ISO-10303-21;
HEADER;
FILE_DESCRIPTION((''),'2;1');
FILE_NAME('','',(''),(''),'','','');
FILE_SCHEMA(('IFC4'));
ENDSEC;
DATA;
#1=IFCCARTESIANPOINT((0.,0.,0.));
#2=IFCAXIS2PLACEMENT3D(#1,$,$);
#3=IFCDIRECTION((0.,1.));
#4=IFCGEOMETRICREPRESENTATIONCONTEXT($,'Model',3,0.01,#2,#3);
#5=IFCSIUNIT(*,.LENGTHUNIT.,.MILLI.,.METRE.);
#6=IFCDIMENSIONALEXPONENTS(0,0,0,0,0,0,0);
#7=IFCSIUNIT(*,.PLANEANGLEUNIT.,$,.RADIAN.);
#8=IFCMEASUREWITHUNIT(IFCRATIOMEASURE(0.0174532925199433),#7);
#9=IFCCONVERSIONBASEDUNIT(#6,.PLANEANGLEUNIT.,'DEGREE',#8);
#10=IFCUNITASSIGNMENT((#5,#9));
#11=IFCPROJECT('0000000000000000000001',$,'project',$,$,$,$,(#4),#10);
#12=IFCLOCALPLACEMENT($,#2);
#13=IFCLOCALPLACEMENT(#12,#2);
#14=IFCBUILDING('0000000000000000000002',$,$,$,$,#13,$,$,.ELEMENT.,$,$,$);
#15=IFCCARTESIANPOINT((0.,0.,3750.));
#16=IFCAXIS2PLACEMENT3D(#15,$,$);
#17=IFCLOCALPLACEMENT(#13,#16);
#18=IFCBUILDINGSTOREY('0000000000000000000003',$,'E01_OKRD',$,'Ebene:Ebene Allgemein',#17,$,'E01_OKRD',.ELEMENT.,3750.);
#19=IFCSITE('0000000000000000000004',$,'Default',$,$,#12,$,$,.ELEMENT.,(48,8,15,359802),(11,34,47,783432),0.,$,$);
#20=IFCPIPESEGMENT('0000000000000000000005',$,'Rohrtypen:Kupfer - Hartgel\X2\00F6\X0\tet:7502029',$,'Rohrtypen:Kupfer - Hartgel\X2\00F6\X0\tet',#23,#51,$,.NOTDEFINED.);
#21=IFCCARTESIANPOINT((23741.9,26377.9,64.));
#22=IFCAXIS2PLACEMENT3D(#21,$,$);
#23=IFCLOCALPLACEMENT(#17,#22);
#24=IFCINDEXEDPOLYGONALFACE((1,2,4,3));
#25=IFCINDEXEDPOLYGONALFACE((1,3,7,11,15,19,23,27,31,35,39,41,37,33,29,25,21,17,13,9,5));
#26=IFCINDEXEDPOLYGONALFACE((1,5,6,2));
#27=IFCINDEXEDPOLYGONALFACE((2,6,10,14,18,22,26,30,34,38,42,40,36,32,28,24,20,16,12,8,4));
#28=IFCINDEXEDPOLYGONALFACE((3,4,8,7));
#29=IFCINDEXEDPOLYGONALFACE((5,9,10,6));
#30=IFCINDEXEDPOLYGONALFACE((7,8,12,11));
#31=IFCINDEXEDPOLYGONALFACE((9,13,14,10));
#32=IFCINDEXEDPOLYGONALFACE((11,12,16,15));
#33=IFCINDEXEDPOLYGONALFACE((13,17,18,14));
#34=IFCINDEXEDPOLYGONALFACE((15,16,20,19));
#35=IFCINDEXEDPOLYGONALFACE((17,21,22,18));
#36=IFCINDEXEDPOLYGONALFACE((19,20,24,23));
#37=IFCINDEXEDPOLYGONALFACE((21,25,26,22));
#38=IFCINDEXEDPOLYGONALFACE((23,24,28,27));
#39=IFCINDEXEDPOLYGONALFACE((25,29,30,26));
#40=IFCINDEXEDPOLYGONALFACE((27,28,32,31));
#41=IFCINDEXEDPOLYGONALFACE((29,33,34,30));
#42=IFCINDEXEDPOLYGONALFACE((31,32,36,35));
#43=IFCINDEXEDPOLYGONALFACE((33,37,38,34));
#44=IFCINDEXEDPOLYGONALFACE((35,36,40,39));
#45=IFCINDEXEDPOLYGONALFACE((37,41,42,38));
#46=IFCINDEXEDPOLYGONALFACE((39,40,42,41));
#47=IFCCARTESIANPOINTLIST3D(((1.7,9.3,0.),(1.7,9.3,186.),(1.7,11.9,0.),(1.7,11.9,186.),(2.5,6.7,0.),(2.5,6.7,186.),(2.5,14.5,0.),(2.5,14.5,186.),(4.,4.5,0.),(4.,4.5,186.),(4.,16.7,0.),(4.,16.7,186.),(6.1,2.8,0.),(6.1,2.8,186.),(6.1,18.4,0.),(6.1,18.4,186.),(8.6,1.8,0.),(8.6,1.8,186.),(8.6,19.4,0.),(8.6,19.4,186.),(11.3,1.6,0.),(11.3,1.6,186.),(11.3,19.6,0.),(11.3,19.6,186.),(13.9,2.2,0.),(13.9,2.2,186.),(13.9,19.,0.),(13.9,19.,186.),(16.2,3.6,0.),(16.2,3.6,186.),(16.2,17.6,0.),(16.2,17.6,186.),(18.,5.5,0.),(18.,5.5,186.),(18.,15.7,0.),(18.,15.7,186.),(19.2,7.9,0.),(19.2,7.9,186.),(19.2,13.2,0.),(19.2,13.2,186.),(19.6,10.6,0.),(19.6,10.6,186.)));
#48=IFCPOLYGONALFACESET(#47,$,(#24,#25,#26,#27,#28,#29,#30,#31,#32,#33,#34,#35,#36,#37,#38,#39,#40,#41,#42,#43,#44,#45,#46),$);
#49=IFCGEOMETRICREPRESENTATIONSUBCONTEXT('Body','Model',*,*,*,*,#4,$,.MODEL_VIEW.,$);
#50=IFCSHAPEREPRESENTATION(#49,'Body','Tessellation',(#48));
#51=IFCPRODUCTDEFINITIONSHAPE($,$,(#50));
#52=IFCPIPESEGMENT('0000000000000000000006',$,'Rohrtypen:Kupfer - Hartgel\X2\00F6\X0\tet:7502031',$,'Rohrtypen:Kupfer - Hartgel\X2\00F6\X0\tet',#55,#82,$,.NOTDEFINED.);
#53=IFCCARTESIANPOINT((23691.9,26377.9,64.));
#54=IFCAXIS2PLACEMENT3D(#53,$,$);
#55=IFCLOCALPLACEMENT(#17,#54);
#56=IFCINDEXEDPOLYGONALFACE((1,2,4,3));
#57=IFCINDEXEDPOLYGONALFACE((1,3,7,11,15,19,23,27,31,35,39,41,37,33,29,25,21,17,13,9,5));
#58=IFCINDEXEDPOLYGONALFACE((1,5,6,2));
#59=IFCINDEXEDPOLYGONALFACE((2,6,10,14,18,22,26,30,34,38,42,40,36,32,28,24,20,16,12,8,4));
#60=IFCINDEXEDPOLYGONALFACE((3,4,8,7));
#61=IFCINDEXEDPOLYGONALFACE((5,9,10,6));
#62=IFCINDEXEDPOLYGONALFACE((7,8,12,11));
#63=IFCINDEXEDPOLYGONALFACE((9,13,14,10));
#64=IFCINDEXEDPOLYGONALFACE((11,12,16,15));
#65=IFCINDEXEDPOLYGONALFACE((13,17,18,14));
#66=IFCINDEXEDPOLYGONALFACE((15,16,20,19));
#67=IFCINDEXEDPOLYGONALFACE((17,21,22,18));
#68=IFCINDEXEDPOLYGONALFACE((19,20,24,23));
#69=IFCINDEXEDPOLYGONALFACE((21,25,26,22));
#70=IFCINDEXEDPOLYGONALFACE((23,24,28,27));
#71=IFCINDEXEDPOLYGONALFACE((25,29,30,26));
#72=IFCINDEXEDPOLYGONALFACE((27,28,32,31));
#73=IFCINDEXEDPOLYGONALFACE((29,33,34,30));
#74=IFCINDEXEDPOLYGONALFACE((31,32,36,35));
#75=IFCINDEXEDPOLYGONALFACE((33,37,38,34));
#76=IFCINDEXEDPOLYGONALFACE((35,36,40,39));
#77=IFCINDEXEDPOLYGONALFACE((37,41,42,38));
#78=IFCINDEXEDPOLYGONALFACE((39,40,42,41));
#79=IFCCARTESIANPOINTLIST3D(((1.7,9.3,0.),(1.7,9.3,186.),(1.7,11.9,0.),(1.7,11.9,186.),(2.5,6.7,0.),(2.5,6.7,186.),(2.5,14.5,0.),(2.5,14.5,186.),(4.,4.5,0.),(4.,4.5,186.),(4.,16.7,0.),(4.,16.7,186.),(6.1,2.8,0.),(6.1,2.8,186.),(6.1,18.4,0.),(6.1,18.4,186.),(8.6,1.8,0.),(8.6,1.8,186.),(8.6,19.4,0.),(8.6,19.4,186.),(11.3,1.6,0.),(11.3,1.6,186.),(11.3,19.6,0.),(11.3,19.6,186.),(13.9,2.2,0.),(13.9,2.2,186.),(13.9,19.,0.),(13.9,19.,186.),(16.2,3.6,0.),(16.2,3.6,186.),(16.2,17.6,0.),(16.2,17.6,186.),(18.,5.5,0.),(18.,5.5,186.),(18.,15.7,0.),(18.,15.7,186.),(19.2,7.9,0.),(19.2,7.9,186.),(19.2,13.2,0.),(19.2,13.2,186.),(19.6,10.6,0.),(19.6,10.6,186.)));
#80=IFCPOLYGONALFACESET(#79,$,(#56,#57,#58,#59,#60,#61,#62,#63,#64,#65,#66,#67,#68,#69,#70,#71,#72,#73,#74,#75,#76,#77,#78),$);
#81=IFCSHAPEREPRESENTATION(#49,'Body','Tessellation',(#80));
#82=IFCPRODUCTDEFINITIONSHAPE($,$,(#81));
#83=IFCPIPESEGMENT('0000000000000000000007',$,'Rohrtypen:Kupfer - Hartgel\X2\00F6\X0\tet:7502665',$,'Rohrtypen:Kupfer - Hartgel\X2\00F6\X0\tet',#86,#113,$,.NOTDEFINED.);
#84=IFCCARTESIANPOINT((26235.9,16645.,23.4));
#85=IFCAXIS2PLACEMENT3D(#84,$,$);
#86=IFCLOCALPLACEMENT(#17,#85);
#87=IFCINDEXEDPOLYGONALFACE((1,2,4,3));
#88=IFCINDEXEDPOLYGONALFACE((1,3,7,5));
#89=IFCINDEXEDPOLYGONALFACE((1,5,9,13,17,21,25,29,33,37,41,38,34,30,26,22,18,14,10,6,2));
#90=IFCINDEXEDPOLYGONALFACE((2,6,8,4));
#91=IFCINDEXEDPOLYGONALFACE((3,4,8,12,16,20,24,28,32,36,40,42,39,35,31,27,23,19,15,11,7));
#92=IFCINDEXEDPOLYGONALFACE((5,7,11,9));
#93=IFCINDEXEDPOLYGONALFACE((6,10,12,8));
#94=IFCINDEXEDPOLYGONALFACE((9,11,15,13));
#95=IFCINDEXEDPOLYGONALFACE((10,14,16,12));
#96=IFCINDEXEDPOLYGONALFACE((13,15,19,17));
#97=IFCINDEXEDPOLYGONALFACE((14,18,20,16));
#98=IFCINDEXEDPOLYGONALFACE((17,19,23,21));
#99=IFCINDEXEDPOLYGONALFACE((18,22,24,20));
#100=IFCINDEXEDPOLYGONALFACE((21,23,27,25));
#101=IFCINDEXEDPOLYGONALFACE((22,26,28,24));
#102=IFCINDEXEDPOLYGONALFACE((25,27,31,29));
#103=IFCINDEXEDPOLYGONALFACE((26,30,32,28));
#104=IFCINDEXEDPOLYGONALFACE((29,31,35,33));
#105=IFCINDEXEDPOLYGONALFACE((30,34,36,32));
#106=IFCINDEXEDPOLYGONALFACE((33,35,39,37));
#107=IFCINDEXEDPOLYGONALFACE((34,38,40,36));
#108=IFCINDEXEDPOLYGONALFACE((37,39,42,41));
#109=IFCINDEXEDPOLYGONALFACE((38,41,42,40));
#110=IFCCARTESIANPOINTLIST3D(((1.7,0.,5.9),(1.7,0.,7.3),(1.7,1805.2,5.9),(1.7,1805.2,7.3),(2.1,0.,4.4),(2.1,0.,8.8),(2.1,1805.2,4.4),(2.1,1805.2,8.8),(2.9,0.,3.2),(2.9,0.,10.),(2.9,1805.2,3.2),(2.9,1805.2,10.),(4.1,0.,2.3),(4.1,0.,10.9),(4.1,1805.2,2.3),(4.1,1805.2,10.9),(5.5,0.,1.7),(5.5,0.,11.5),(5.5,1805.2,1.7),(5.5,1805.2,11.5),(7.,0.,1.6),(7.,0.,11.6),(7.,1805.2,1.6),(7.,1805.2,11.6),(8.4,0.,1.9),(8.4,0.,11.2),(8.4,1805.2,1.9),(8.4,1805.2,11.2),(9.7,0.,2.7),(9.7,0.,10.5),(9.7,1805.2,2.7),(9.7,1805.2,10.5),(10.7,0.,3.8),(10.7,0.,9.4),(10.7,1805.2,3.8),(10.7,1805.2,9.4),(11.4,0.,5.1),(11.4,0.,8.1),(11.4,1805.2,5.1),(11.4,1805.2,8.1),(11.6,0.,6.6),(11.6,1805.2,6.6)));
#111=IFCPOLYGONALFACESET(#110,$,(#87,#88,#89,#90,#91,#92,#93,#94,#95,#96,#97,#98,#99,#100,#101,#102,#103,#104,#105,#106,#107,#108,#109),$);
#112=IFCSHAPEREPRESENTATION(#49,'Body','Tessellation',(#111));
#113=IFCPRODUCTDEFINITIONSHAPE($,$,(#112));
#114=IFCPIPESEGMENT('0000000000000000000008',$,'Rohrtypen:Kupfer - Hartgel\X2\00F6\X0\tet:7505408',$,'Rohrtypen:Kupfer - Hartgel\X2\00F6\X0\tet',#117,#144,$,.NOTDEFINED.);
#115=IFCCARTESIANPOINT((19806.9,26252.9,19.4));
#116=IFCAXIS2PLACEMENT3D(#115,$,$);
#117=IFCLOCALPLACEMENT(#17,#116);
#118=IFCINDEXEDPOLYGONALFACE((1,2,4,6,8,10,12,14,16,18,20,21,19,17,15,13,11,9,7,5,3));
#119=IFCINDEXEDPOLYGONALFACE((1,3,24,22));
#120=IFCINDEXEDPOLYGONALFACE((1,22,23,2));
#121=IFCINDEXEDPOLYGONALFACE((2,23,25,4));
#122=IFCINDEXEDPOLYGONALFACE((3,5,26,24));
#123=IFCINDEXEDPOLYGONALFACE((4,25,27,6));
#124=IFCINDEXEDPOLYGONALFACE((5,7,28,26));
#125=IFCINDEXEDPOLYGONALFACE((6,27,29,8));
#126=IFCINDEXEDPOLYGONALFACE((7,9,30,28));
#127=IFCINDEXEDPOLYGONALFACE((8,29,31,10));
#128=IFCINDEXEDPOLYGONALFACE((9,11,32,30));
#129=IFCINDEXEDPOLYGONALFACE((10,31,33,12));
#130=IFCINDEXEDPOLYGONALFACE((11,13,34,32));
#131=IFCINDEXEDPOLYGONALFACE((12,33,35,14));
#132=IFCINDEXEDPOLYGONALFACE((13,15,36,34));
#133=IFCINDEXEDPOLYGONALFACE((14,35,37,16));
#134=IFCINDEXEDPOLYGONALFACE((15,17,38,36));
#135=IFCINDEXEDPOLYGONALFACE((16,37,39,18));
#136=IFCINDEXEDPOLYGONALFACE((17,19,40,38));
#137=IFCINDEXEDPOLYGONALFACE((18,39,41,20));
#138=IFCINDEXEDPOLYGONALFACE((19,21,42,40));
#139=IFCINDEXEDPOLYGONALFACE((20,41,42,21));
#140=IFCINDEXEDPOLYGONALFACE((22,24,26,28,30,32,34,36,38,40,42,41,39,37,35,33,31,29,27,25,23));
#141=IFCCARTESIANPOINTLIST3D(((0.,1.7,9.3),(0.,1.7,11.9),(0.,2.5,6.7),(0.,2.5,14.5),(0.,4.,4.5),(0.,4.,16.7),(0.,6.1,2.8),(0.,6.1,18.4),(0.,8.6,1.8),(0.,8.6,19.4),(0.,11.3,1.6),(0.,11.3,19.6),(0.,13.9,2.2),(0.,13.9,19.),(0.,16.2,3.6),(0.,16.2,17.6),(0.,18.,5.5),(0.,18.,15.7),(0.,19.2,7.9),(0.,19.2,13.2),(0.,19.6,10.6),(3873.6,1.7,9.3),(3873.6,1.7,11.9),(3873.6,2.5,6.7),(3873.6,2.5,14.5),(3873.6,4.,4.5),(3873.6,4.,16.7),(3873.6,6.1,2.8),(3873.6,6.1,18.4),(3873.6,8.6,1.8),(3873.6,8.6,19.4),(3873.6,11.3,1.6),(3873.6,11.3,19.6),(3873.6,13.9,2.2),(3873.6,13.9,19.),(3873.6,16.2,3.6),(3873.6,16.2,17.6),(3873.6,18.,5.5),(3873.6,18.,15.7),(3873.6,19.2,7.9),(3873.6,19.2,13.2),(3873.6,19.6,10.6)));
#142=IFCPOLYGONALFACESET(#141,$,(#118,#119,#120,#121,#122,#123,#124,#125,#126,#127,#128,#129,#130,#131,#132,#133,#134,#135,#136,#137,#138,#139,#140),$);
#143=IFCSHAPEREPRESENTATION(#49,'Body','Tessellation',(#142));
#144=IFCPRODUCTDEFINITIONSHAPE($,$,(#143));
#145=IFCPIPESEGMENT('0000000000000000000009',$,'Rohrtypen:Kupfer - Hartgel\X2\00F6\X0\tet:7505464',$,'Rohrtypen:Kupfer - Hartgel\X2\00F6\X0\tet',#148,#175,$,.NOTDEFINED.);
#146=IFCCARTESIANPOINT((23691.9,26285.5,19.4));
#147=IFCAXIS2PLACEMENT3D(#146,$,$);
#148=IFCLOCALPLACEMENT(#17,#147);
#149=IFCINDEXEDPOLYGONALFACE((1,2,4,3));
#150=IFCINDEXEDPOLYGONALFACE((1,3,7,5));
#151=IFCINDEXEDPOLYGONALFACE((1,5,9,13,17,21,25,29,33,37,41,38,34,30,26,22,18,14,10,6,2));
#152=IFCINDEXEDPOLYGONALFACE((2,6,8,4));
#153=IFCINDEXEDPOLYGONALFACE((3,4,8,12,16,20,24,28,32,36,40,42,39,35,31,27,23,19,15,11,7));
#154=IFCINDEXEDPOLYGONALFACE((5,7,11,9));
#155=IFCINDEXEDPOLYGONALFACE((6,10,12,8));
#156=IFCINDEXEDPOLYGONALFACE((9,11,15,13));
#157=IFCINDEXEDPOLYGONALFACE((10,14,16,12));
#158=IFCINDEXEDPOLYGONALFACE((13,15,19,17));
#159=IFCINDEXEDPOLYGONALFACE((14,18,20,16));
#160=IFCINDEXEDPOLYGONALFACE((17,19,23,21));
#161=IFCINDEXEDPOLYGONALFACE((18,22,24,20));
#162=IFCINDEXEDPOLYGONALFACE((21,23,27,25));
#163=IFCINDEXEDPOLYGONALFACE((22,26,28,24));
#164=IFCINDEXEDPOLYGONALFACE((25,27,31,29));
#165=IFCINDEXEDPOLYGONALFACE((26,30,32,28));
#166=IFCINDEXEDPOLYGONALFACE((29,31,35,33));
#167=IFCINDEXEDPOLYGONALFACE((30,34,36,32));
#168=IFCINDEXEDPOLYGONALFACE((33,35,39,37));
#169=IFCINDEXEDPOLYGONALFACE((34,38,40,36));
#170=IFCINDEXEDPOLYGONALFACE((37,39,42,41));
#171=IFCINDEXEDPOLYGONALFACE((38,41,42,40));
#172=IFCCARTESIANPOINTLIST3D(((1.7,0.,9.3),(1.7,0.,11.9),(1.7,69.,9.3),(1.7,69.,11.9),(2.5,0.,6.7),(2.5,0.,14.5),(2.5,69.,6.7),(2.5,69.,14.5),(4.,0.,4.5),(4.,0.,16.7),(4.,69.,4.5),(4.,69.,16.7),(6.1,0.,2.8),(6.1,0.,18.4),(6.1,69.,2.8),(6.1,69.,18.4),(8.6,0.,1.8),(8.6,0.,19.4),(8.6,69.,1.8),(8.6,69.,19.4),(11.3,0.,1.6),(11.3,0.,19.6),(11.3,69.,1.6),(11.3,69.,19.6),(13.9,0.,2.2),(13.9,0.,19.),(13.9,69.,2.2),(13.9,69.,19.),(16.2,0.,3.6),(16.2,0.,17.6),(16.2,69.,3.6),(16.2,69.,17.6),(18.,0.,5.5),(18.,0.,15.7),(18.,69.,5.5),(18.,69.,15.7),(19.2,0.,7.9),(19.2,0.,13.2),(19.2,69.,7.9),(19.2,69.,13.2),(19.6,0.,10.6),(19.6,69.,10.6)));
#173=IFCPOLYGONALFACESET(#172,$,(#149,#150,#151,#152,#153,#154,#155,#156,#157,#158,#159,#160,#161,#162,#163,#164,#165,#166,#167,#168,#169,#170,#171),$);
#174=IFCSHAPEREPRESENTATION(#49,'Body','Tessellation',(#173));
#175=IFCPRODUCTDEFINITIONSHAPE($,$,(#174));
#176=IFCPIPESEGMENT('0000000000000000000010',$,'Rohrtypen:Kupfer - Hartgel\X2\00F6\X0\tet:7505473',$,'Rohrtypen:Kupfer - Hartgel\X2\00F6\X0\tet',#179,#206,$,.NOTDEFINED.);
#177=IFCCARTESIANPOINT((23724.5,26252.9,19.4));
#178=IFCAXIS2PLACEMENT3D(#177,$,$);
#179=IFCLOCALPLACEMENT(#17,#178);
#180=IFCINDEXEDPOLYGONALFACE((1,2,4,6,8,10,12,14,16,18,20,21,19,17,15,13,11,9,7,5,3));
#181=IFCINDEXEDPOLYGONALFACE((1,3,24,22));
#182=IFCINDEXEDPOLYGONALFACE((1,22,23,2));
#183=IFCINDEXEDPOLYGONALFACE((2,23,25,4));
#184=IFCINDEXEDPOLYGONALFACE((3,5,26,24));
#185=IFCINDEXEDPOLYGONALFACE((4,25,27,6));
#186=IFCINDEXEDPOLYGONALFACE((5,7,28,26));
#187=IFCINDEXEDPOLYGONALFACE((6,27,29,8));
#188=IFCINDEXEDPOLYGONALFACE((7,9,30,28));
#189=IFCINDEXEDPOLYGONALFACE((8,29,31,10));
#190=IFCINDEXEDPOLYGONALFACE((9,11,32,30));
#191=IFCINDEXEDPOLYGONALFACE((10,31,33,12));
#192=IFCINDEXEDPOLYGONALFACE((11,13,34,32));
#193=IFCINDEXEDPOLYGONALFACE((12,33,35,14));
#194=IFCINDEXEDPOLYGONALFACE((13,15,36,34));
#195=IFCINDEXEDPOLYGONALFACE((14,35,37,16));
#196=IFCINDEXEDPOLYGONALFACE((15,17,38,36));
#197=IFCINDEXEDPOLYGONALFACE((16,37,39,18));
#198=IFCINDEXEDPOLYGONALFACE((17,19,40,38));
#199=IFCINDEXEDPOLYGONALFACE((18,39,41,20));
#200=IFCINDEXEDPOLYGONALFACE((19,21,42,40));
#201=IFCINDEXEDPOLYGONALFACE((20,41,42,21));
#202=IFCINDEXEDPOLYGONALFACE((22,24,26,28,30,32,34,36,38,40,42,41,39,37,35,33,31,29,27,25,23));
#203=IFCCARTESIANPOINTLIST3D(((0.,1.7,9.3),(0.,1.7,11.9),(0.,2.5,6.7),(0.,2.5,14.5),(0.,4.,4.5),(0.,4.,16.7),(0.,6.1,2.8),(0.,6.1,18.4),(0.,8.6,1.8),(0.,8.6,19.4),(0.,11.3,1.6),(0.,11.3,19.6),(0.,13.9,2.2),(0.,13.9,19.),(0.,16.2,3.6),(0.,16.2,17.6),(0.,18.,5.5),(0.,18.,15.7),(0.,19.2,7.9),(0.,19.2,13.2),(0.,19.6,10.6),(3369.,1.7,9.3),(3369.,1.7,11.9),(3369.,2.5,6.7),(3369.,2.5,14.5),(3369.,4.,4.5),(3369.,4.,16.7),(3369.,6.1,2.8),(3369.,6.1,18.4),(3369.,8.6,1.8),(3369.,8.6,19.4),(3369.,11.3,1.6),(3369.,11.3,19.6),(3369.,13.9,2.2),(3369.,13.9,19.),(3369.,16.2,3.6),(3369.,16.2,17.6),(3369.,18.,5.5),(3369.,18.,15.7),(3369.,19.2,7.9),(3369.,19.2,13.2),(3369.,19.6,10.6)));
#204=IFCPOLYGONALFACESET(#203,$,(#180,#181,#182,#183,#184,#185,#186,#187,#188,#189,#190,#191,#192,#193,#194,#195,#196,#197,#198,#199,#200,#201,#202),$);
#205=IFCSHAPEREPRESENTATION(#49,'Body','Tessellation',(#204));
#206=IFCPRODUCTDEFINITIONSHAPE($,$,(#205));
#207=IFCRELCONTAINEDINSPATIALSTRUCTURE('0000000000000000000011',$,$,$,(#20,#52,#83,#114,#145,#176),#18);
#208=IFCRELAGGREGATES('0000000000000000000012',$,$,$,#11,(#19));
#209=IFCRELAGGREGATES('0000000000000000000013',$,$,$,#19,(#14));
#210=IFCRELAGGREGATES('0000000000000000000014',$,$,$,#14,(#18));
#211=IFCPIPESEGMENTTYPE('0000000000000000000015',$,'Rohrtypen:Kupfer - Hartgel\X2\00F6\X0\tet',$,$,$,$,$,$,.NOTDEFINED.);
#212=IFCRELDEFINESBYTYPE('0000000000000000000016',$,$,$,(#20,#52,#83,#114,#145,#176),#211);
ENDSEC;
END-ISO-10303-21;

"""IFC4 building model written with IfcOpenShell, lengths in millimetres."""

from ifc_helpers import new_model, entity, si_unit, converted_unit, direction, frame, frame_2d, origin, origin_2d_with_axis, place, context, subcontext, project, spatial, circle, extrude, type_object, element, save


model = new_model("IFC4")

# Units and contexts
model_context = context("Model", 3, precision=0.01, world=origin(), true_north=direction((0.0, 1.0)))
body_context = subcontext(model_context, "Body", "Model", "MODEL_VIEW")
ifc_project = project(units=[si_unit("LENGTHUNIT", "METRE", prefix="MILLI"), converted_unit("PLANEANGLEUNIT", "DEGREE", entity("IfcRatioMeasure", 0.0174532925199433), si_unit("PLANEANGLEUNIT", "RADIAN"), dimensions=[0, 0, 0, 0, 0, 0, 0])], contexts=[model_context])

# Site, building, storey
site_placement = place(None, origin())
site = spatial("IfcSite", under=ifc_project, at=site_placement, Name="Default", CompositionType="ELEMENT", RefLatitude=(48, 8, 15, 359802), RefLongitude=(11, 34, 47, 783432), RefElevation=0.0)
building_placement = place(site_placement, origin())
building = spatial("IfcBuilding", under=site, at=building_placement, CompositionType="ELEMENT")
storey_placement = place(building_placement, frame((0.0, 0.0, 3750.0)))
storey = spatial("IfcBuildingStorey", under=building, at=storey_placement, Name="E01_OKRD", ObjectType="Ebene:Ebene Allgemein", LongName="E01_OKRD", CompositionType="ELEMENT", Elevation=3750.0)

# Pipe segments
pipe_segment_type = type_object("IfcPipeSegmentType", Name="Rohrtypen:Kupfer - Hartgelötet", PredefinedType="NOTDEFINED")
pipe_segment_1_placement = place(storey_placement, frame((23741.9, 26377.9, 64.0)))
element("IfcPipeSegment", 1, at=pipe_segment_1_placement, inside=storey, type_object=pipe_segment_type, Name="Rohrtypen:Kupfer - Hartgelötet:7502029", ObjectType="Rohrtypen:Kupfer - Hartgelötet", PredefinedType="NOTDEFINED", context=body_context, shape_type="SweptSolid", body=[
    extrude(circle(Radius=9.0, at=origin_2d_with_axis()), frame((10.6, 10.6, 0.0)), (0.0, 0.0, 1.0), 186.0),
])
pipe_segment_2_placement = place(storey_placement, frame((23691.9, 26377.9, 64.0)))
element("IfcPipeSegment", 2, at=pipe_segment_2_placement, inside=storey, type_object=pipe_segment_type, Name="Rohrtypen:Kupfer - Hartgelötet:7502031", ObjectType="Rohrtypen:Kupfer - Hartgelötet", PredefinedType="NOTDEFINED", context=body_context, shape_type="SweptSolid", body=[
    extrude(circle(Radius=9.0, at=origin_2d_with_axis()), frame((10.6, 10.6, 0.0)), (0.0, 0.0, 1.0), 186.0),
])
pipe_segment_3_placement = place(storey_placement, frame((26235.9, 16645.0, 23.4)))
element("IfcPipeSegment", 3, at=pipe_segment_3_placement, inside=storey, type_object=pipe_segment_type, Name="Rohrtypen:Kupfer - Hartgelötet:7502665", ObjectType="Rohrtypen:Kupfer - Hartgelötet", PredefinedType="NOTDEFINED", context=body_context, shape_type="SweptSolid", body=[
    extrude(circle(Radius=5.0, at=origin_2d_with_axis()), frame((6.6, 0.0, 6.6), z_axis=(0.0, 1.0, 0.0), x_axis=(1.0, 0.0, 0.0)), (0.0, 0.0, 1.0), 1805.2),
])
pipe_segment_4_placement = place(storey_placement, frame((19806.9, 26252.9, 19.4)))
element("IfcPipeSegment", 4, at=pipe_segment_4_placement, inside=storey, type_object=pipe_segment_type, Name="Rohrtypen:Kupfer - Hartgelötet:7505408", ObjectType="Rohrtypen:Kupfer - Hartgelötet", PredefinedType="NOTDEFINED", context=body_context, shape_type="SweptSolid", body=[
    extrude(circle(Radius=9.0, at=origin_2d_with_axis()), frame((0.0, 10.6, 10.6), z_axis=(1.0, 0.0, 0.0), x_axis=(0.0, 1.0, 0.0)), (0.0, 0.0, 1.0), 3873.6),
])
pipe_segment_5_placement = place(storey_placement, frame((23691.9, 26285.5, 19.4)))
element("IfcPipeSegment", 5, at=pipe_segment_5_placement, inside=storey, type_object=pipe_segment_type, Name="Rohrtypen:Kupfer - Hartgelötet:7505464", ObjectType="Rohrtypen:Kupfer - Hartgelötet", PredefinedType="NOTDEFINED", context=body_context, shape_type="SweptSolid", body=[
    extrude(circle(Radius=9.0, at=origin_2d_with_axis()), frame((10.6, 0.0, 10.6), z_axis=(0.0, 1.0, 0.0), x_axis=(1.0, 0.0, 0.0)), (0.0, 0.0, 1.0), 69.0),
])
pipe_segment_6_placement = place(storey_placement, frame((23724.5, 26252.9, 19.4)))
element("IfcPipeSegment", 6, at=pipe_segment_6_placement, inside=storey, type_object=pipe_segment_type, Name="Rohrtypen:Kupfer - Hartgelötet:7505473", ObjectType="Rohrtypen:Kupfer - Hartgelötet", PredefinedType="NOTDEFINED", context=body_context, shape_type="SweptSolid", body=[
    extrude(circle(Radius=9.0, at=frame_2d((0.0, 0.0), x_axis=(1.0, 0.0))), frame((0.0, 10.6, 10.6), z_axis=(1.0, 0.0, 0.0), x_axis=(0.0, 1.0, 0.0)), (0.0, 0.0, 1.0), 3369.0),
])

save(model, "model.ifc")
